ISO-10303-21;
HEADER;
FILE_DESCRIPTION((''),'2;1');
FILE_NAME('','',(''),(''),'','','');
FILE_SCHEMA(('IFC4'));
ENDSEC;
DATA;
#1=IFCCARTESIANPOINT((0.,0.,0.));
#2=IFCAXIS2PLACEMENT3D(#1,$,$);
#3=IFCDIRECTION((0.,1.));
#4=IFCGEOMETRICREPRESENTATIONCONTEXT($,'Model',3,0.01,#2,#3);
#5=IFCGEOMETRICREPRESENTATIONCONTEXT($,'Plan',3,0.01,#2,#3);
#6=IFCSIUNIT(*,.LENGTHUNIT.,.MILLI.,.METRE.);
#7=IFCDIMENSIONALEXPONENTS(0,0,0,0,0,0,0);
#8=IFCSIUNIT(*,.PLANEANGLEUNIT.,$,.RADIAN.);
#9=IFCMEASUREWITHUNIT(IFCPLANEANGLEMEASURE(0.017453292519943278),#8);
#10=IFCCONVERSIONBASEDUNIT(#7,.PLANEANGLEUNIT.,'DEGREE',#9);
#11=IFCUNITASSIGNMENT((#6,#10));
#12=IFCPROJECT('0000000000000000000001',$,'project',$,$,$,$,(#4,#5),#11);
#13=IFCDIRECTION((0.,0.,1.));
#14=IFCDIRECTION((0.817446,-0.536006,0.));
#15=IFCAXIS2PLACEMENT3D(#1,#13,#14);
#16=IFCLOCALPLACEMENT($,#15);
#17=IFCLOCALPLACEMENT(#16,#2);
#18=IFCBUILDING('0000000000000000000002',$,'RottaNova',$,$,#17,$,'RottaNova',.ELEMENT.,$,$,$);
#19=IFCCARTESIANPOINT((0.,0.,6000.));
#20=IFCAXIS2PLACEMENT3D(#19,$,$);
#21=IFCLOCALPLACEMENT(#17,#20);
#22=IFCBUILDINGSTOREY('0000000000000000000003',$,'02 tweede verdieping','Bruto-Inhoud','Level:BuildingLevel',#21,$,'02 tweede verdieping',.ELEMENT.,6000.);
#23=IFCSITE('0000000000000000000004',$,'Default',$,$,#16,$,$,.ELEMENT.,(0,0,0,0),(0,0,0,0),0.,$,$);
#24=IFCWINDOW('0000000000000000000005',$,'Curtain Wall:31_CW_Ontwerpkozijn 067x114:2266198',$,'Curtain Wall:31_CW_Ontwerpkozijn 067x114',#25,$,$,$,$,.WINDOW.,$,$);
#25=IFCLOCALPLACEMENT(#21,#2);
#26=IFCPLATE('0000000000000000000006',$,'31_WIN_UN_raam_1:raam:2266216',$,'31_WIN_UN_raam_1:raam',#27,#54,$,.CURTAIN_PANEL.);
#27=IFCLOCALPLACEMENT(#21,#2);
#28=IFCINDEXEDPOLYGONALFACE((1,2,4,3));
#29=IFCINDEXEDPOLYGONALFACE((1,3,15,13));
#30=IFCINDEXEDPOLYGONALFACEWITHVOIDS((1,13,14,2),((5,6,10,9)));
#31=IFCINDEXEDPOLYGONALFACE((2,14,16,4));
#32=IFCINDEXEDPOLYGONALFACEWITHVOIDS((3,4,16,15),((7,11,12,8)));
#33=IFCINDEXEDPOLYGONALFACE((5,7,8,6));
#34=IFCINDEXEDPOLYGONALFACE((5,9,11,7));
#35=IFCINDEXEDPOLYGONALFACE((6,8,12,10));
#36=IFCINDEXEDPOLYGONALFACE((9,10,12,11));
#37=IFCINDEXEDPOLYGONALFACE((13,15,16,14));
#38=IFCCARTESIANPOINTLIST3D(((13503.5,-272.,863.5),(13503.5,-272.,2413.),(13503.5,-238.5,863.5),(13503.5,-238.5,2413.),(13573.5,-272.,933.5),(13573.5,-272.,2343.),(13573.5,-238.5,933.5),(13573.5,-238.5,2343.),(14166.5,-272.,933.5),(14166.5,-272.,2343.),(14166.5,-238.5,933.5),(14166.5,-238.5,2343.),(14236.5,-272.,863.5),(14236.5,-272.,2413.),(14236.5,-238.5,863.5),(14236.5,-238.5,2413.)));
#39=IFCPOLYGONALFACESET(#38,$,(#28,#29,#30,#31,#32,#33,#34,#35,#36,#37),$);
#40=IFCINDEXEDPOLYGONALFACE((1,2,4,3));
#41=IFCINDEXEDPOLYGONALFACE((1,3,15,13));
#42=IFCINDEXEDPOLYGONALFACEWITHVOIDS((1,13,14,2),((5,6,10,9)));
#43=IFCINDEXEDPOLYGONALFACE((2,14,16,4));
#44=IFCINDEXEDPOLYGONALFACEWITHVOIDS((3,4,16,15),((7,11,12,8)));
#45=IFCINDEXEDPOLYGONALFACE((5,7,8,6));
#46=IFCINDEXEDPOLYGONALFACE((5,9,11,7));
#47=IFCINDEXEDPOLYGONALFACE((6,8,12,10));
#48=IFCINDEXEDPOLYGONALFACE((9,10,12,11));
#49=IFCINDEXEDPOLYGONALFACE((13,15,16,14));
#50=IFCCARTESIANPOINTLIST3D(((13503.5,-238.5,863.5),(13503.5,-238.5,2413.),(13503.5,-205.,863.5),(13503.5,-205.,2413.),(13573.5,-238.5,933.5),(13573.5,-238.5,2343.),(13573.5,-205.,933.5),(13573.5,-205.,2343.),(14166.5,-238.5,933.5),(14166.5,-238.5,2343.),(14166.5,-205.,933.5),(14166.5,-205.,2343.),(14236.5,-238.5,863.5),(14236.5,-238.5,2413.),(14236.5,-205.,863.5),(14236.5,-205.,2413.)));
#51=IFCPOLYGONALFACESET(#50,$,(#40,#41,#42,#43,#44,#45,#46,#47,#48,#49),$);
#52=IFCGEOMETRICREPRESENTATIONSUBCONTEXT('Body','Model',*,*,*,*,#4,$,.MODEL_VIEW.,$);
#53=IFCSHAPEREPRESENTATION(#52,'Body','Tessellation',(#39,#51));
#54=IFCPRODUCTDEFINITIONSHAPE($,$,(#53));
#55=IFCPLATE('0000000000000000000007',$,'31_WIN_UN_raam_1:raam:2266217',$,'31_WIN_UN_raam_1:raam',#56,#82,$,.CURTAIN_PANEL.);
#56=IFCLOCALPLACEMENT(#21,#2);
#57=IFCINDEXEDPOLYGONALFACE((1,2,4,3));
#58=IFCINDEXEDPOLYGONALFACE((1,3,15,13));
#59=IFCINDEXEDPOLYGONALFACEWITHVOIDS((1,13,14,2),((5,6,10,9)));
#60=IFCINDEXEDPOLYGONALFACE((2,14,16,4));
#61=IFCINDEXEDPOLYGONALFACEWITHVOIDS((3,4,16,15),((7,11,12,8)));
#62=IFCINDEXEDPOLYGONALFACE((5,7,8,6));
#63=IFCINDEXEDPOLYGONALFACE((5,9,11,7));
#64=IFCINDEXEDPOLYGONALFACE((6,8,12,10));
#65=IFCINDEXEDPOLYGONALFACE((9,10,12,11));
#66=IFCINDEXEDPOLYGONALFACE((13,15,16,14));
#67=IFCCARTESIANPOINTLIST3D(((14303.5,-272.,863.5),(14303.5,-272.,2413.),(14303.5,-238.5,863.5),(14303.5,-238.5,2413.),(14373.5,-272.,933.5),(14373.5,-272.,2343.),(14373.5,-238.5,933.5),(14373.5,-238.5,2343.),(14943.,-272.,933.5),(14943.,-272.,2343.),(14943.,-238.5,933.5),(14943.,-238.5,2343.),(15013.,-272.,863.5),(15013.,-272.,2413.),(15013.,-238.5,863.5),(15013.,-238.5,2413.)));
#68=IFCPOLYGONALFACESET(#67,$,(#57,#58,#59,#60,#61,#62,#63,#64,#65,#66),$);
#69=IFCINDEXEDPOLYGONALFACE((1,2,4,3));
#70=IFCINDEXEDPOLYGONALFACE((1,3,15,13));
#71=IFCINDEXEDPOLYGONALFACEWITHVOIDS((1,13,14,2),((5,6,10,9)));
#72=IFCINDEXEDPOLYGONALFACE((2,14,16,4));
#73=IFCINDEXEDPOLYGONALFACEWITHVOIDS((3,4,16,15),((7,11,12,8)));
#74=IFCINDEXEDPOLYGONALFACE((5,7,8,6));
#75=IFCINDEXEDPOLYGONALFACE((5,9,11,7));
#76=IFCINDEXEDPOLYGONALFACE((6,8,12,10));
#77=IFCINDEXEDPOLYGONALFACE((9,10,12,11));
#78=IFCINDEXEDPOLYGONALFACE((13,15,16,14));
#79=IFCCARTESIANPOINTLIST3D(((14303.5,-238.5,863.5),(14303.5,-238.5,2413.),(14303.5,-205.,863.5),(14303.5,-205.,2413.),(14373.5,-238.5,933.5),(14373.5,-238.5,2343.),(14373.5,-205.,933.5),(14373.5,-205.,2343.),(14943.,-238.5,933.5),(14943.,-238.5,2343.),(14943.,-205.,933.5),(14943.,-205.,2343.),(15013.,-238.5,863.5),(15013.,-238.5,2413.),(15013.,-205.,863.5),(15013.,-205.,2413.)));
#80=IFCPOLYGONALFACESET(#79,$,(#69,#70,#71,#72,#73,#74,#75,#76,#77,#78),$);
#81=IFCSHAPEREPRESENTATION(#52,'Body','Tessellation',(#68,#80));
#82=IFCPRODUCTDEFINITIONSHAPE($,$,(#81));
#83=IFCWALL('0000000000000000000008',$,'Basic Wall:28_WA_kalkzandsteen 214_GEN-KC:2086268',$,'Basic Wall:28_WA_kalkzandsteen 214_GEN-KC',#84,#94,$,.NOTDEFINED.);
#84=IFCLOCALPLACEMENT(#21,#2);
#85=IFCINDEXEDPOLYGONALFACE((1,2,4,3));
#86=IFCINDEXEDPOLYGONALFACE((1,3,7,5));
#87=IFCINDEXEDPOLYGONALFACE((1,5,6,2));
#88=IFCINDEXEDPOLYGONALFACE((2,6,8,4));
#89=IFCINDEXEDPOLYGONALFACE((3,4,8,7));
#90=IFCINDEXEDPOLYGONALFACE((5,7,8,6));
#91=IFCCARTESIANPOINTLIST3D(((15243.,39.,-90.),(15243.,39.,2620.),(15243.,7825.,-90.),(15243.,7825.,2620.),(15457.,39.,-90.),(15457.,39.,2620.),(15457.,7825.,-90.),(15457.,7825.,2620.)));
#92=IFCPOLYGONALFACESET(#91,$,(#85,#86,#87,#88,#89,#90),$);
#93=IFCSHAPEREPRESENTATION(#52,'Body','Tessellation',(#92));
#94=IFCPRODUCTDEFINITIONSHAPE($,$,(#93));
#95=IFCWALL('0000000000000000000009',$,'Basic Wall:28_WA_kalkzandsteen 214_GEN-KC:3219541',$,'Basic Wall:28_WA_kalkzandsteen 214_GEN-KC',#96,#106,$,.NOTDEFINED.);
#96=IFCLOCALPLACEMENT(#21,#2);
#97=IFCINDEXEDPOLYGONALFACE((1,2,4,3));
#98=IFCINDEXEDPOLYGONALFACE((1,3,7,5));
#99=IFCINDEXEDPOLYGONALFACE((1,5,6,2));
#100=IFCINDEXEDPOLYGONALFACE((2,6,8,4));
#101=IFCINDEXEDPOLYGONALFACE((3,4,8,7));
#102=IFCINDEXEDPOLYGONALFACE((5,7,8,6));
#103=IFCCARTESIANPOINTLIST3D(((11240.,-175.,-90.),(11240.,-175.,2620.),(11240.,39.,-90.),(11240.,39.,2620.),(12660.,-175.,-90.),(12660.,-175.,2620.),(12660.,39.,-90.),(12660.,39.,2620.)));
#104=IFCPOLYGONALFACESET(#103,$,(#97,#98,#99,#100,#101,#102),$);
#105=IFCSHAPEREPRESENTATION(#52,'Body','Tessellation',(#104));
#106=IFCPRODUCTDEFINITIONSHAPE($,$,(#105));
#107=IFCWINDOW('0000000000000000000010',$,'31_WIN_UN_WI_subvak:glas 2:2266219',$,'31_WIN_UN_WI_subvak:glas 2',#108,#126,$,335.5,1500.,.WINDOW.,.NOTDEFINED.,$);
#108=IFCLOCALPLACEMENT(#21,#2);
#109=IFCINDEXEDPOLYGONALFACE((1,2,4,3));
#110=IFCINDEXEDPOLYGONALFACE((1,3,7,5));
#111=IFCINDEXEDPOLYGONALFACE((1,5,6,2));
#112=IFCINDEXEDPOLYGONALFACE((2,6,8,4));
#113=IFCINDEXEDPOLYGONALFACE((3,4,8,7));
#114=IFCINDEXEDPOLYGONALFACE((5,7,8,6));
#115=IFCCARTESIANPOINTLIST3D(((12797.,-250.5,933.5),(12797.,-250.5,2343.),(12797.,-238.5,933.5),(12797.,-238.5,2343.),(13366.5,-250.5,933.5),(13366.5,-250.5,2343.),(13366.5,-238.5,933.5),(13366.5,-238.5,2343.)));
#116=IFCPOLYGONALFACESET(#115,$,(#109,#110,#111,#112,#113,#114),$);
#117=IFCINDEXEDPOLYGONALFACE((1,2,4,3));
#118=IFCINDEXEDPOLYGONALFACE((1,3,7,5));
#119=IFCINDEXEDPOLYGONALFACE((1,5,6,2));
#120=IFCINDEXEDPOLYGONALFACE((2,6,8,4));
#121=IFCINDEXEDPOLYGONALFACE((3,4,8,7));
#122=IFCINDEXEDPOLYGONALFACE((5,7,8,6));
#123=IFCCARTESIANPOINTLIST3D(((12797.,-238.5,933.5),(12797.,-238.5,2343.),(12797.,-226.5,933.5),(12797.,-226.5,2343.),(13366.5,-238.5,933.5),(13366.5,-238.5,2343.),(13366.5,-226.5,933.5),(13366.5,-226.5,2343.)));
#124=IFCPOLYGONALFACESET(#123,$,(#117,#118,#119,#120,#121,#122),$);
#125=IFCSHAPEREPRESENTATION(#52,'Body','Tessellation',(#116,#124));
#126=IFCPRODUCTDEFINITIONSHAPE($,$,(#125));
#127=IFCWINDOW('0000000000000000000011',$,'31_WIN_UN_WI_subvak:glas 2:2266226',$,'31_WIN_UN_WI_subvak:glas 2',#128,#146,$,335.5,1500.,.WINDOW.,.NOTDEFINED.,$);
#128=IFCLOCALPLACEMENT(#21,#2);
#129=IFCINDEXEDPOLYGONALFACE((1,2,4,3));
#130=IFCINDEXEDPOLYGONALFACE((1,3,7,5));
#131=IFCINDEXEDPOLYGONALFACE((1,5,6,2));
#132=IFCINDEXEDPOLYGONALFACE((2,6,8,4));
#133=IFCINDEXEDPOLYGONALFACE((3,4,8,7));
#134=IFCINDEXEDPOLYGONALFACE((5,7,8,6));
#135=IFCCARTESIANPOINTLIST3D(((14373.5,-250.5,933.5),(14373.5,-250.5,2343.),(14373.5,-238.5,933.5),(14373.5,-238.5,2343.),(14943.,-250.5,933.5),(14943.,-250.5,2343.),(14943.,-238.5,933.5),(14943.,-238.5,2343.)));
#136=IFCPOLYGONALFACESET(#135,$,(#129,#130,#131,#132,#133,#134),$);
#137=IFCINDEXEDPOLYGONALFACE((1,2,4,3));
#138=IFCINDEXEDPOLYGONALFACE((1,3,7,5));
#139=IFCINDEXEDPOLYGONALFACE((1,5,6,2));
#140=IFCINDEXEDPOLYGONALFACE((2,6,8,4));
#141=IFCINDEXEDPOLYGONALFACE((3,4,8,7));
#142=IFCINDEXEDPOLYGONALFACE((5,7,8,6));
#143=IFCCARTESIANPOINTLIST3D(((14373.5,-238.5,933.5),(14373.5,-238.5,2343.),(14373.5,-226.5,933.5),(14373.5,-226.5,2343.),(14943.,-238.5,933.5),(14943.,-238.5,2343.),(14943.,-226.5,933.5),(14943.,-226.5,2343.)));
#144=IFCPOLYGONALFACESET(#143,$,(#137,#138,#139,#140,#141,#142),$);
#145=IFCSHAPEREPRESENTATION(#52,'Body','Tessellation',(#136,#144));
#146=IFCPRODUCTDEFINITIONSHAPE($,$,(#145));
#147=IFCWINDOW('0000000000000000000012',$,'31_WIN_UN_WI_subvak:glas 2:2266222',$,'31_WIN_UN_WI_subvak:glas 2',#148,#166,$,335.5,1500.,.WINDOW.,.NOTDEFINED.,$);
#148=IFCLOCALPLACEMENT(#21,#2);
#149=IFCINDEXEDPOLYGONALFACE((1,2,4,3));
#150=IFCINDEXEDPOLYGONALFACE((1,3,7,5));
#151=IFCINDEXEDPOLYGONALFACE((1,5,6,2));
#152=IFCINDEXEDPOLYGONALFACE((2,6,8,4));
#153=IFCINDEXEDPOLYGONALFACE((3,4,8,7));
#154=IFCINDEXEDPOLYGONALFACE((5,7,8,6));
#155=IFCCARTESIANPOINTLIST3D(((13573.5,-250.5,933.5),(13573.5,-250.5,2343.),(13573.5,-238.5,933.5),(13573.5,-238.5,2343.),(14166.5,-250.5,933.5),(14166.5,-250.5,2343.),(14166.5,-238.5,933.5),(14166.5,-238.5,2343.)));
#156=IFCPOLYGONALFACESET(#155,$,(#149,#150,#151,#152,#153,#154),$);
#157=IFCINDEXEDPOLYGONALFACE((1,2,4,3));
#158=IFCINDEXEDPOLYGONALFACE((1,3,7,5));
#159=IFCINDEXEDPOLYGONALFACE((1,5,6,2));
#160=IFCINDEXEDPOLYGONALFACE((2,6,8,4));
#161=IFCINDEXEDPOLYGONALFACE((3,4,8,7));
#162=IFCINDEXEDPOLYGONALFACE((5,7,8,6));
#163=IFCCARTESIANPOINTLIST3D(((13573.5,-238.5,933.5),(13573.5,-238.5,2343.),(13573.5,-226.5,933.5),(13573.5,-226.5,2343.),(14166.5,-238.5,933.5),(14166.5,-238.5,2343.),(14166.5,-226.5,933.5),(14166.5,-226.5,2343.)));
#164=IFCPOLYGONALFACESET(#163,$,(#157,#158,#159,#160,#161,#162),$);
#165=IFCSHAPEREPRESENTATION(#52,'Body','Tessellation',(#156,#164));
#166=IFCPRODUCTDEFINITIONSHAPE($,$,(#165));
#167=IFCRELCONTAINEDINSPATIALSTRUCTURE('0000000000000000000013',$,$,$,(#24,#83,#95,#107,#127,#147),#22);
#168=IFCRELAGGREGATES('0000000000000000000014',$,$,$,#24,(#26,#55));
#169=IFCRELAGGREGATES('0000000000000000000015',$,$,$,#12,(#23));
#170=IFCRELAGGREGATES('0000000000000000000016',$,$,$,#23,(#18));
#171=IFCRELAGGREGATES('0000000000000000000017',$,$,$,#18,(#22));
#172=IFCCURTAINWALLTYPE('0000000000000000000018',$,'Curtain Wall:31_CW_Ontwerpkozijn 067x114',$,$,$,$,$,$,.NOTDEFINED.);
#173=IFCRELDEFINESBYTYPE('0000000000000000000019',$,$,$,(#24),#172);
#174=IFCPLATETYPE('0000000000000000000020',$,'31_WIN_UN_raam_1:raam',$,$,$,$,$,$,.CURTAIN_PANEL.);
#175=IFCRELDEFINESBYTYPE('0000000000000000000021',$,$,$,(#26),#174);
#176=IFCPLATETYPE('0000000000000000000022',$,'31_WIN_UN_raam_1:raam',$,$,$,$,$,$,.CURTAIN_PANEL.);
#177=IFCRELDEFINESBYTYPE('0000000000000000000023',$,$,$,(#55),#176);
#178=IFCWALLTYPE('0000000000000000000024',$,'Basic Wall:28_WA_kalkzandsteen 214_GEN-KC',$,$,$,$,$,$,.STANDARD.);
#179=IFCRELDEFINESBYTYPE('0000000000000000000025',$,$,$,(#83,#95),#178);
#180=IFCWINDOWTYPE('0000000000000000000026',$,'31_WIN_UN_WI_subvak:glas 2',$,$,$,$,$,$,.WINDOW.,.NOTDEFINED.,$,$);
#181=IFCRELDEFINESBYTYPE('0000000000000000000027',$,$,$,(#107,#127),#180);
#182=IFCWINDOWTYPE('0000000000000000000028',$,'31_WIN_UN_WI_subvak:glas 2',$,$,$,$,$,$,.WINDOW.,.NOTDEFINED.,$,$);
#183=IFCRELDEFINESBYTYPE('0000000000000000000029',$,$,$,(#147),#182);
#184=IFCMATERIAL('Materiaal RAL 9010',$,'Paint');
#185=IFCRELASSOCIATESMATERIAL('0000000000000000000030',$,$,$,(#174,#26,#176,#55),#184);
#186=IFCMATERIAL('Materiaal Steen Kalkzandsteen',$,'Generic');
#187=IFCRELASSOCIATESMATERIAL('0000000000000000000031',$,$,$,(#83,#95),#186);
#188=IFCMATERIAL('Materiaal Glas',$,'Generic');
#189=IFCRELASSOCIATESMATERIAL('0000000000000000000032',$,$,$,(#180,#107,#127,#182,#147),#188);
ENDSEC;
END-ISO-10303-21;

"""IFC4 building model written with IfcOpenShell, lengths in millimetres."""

from ifc_helpers import new_model, entity, si_unit, converted_unit, direction, frame, origin, place, context, subcontext, project, spatial, indexed_curve, outline, extrude, source, transform, mapped, material, type_object, type_shapes, element, aggregate, save


model = new_model("IFC4")

# Units and contexts
model_context = context("Model", 3, precision=0.01, world=origin(), true_north=direction((0.0, 1.0)))
plan_context = context("Plan", 3, precision=0.01, world=origin(), true_north=direction((0.0, 1.0)))
body_context = subcontext(model_context, "Body", "Model", "MODEL_VIEW")
ifc_project = project(units=[si_unit("LENGTHUNIT", "METRE", prefix="MILLI"), converted_unit("PLANEANGLEUNIT", "DEGREE", entity("IfcPlaneAngleMeasure", 0.017453292519943278), si_unit("PLANEANGLEUNIT", "RADIAN"), dimensions=[0, 0, 0, 0, 0, 0, 0])], contexts=[model_context, plan_context])

# Site, building, storey
site_placement = place(None, frame((0.0, 0.0, 0.0), z_axis=(0.0, 0.0, 1.0), x_axis=(0.817446, -0.536006, 0.0)))
site = spatial("IfcSite", under=ifc_project, at=site_placement, Name="Default", CompositionType="ELEMENT", RefLatitude=(0, 0, 0, 0), RefLongitude=(0, 0, 0, 0), RefElevation=0.0)
building_placement = place(site_placement, origin())
building = spatial("IfcBuilding", under=site, at=building_placement, Name="RottaNova", LongName="RottaNova", CompositionType="ELEMENT")
storey_placement = place(building_placement, frame((0.0, 0.0, 6000.0)))
storey = spatial("IfcBuildingStorey", under=building, at=storey_placement, Name="02 tweede verdieping", Description="Bruto-Inhoud", ObjectType="Level:BuildingLevel", LongName="02 tweede verdieping", CompositionType="ELEMENT", Elevation=6000.0)

# Window, plates
curtain_wall_type = type_object("IfcCurtainWallType", Name="Curtain Wall:31_CW_Ontwerpkozijn 067x114", PredefinedType="NOTDEFINED")
window_1_placement = place(storey_placement, frame((0.0, 0.0, -6000.0)))
window_1 = element("IfcWindow", 1, at=window_1_placement, inside=storey, type_object=curtain_wall_type, Name="Curtain Wall:31_CW_Ontwerpkozijn 067x114:2266198", ObjectType="Curtain Wall:31_CW_Ontwerpkozijn 067x114", PredefinedType="WINDOW")
ifc_material_1 = material(Name="Materiaal Glas", Category="Generic")
ifc_material_2 = material(Name="Materiaal RAL 9010", Category="Paint")
plate_type_1 = type_object("IfcPlateType", Name="31_WIN_UN_raam_1:raam", PredefinedType="CURTAIN_PANEL", material=ifc_material_2)
shared_shape_1 = source(origin(), body_context, "Body", "SweptSolid", [
    extrude(outline(indexed_curve([(-366.5, -774.8), (366.5, -774.8), (366.5, 774.8), (-366.5, 774.8), (-366.5, -774.8)], self_intersect=False), holes=[indexed_curve([(-296.5, 704.8), (296.5, 704.8), (296.5, -704.8), (-296.5, -704.8), (-296.5, 704.8)], self_intersect=False)]), frame((0.0, -92.0, 774.8), z_axis=(0.0, 1.0, 0.0), x_axis=(1.0, 0.0, 0.0)), (0.0, 0.0, 1.0), 33.5),
    extrude(outline(indexed_curve([(-366.5, -774.8), (366.5, -774.8), (366.5, 774.8), (-366.5, 774.8), (-366.5, -774.8)], self_intersect=False), holes=[indexed_curve([(-296.5, 704.7), (296.5, 704.7), (296.5, -704.8), (-296.5, -704.8), (-296.5, 704.7)], self_intersect=False)]), frame((0.0, -58.5, 774.8), z_axis=(0.0, 1.0, 0.0), x_axis=(1.0, 0.0, 0.0)), (0.0, 0.0, 1.0), 33.5),
])
type_shapes(plate_type_1, [shared_shape_1])
plate_1_placement = place(window_1_placement, frame((13870.0, -180.0, 6863.5)))
plate_1 = element("IfcPlate", 2, at=plate_1_placement, type_object=plate_type_1, material=ifc_material_2, Name="31_WIN_UN_raam_1:raam:2266216", ObjectType="31_WIN_UN_raam_1:raam", PredefinedType="CURTAIN_PANEL", context=body_context, shape_type="MappedRepresentation", body=[
    mapped(shared_shape_1, transform((0.0, 0.0, 0.0), scale=1.0)),
])
plate_type_2 = type_object("IfcPlateType", Name="31_WIN_UN_raam_1:raam", PredefinedType="CURTAIN_PANEL", material=ifc_material_2)
shared_shape_2 = source(origin(), body_context, "Body", "SweptSolid", [
    extrude(outline(indexed_curve([(-354.8, -774.7), (354.8, -774.7), (354.8, 774.7), (-354.8, 774.7), (-354.8, -774.7)], self_intersect=False), holes=[indexed_curve([(-284.8, 704.7), (284.8, 704.7), (284.8, -704.8), (-284.8, -704.8), (-284.8, 704.7)], self_intersect=False)]), frame((0.0, -92.0, 774.8), z_axis=(0.0, 1.0, 0.0), x_axis=(1.0, 0.0, 0.0)), (0.0, 0.0, 1.0), 33.5),
    extrude(outline(indexed_curve([(-354.8, -774.7), (354.8, -774.7), (354.8, 774.7), (-354.8, 774.7), (-354.8, -774.7)], self_intersect=False), holes=[indexed_curve([(-284.8, 704.7), (284.8, 704.7), (284.8, -704.8), (-284.8, -704.8), (-284.8, 704.7)], self_intersect=False)]), frame((0.0, -58.5, 774.8), z_axis=(0.0, 1.0, 0.0), x_axis=(1.0, 0.0, 0.0)), (0.0, 0.0, 1.0), 33.5),
])
type_shapes(plate_type_2, [shared_shape_2])
plate_2_placement = place(window_1_placement, frame((14658.3, -180.0, 6863.5)))
plate_2 = element("IfcPlate", 3, at=plate_2_placement, type_object=plate_type_2, material=ifc_material_2, Name="31_WIN_UN_raam_1:raam:2266217", ObjectType="31_WIN_UN_raam_1:raam", PredefinedType="CURTAIN_PANEL", context=body_context, shape_type="MappedRepresentation", body=[
    mapped(shared_shape_2, transform((0.0, 0.0, 0.0), scale=1.0)),
])
aggregate(window_1, [plate_1, plate_2])

# Walls
ifc_material_3 = material(Name="Materiaal Steen Kalkzandsteen", Category="Generic")
wall_type = type_object("IfcWallType", Name="Basic Wall:28_WA_kalkzandsteen 214_GEN-KC", PredefinedType="STANDARD")
wall_1_placement = place(storey_placement, frame((15350.0, 39.0, -90.0), z_axis=(0.0, 0.0, 1.0), x_axis=(0.0, 1.0, 0.0)))
element("IfcWall", 4, at=wall_1_placement, inside=storey, type_object=wall_type, material=ifc_material_3, Name="Basic Wall:28_WA_kalkzandsteen 214_GEN-KC:2086268", ObjectType="Basic Wall:28_WA_kalkzandsteen 214_GEN-KC", PredefinedType="NOTDEFINED", context=body_context, shape_type="SweptSolid", body=[
    extrude(outline(indexed_curve([(-3893.0, -107.0), (3893.0, -107.0), (3893.0, 107.0), (-3893.0, 107.0), (-3893.0, -107.0)], self_intersect=False)), frame((3893.0, 0.0, 0.0)), (0.0, 0.0, 1.0), 2710.0),
])
wall_2_placement = place(storey_placement, frame((12660.0, -68.0, -90.0), z_axis=(0.0, 0.0, 1.0), x_axis=(-1.0, 0.0, 0.0)))
element("IfcWall", 5, at=wall_2_placement, inside=storey, type_object=wall_type, material=ifc_material_3, Name="Basic Wall:28_WA_kalkzandsteen 214_GEN-KC:3219541", ObjectType="Basic Wall:28_WA_kalkzandsteen 214_GEN-KC", PredefinedType="NOTDEFINED", context=body_context, shape_type="SweptSolid", body=[
    extrude(outline(indexed_curve([(1420.0, 107.0), (0.0, 107.0), (0.0, -107.0), (1420.0, -107.0), (1420.0, 107.0)], self_intersect=False)), origin(), (0.0, 0.0, 1.0), 2710.0),
])

# Windows
window_type_1 = type_object("IfcWindowType", Name="31_WIN_UN_WI_subvak:glas 2", PartitioningType="NOTDEFINED", PredefinedType="WINDOW", material=ifc_material_1)
shared_shape_3 = source(origin(), body_context, "Body", "SweptSolid", [
    extrude(outline(indexed_curve([(-284.7, -6.0), (284.7, -6.0), (284.7, 6.0), (-284.7, 6.0), (-284.7, -6.0)], self_intersect=False)), frame((0.0, -6.0, 0.0)), (0.0, 0.0, 1.0), 1409.5),
    extrude(outline(indexed_curve([(-284.8, -6.0), (284.8, -6.0), (284.8, 6.0), (-284.8, 6.0), (-284.8, -6.0)], self_intersect=False)), frame((0.0, 6.0, 0.0)), (0.0, 0.0, 1.0), 1409.5),
])
type_shapes(window_type_1, [shared_shape_3])
for number, where, name in (
    (6, (13081.8, -238.5, 933.5), "31_WIN_UN_WI_subvak:glas 2:2266219"),
    (7, (14658.3, -238.5, 933.5), "31_WIN_UN_WI_subvak:glas 2:2266226"),
):
    element("IfcWindow", number, at=place(storey_placement, frame(where)), inside=storey, type_object=window_type_1, material=ifc_material_1, Name=name, ObjectType="31_WIN_UN_WI_subvak:glas 2", OverallHeight=335.5, OverallWidth=1500.0, PartitioningType="NOTDEFINED", PredefinedType="WINDOW", context=body_context, shape_type="MappedRepresentation", body=[
        mapped(shared_shape_3, transform((0.0, 0.0, 0.0), scale=1.0)),
    ])
window_type_2 = type_object("IfcWindowType", Name="31_WIN_UN_WI_subvak:glas 2", PartitioningType="NOTDEFINED", PredefinedType="WINDOW", material=ifc_material_1)
shared_shape_4 = source(origin(), body_context, "Body", "SweptSolid", [
    extrude(outline(indexed_curve([(-296.5, -6.0), (296.5, -6.0), (296.5, 6.0), (-296.5, 6.0), (-296.5, -6.0)], self_intersect=False)), frame((0.0, -6.0, 0.0)), (0.0, 0.0, 1.0), 1409.5),
    extrude(outline(indexed_curve([(-296.5, -6.0), (296.5, -6.0), (296.5, 6.0), (-296.5, 6.0), (-296.5, -6.0)], self_intersect=False)), frame((0.0, 6.0, 0.0)), (0.0, 0.0, 1.0), 1409.5),
])
type_shapes(window_type_2, [shared_shape_4])
window_2_placement = place(storey_placement, frame((13870.0, -238.5, 933.5)))
element("IfcWindow", 8, at=window_2_placement, inside=storey, type_object=window_type_2, material=ifc_material_1, Name="31_WIN_UN_WI_subvak:glas 2:2266222", ObjectType="31_WIN_UN_WI_subvak:glas 2", OverallHeight=335.5, OverallWidth=1500.0, PartitioningType="NOTDEFINED", PredefinedType="WINDOW", context=body_context, shape_type="MappedRepresentation", body=[
    mapped(shared_shape_4, transform((0.0, 0.0, 0.0), scale=1.0)),
])

save(model, "model.ifc")
